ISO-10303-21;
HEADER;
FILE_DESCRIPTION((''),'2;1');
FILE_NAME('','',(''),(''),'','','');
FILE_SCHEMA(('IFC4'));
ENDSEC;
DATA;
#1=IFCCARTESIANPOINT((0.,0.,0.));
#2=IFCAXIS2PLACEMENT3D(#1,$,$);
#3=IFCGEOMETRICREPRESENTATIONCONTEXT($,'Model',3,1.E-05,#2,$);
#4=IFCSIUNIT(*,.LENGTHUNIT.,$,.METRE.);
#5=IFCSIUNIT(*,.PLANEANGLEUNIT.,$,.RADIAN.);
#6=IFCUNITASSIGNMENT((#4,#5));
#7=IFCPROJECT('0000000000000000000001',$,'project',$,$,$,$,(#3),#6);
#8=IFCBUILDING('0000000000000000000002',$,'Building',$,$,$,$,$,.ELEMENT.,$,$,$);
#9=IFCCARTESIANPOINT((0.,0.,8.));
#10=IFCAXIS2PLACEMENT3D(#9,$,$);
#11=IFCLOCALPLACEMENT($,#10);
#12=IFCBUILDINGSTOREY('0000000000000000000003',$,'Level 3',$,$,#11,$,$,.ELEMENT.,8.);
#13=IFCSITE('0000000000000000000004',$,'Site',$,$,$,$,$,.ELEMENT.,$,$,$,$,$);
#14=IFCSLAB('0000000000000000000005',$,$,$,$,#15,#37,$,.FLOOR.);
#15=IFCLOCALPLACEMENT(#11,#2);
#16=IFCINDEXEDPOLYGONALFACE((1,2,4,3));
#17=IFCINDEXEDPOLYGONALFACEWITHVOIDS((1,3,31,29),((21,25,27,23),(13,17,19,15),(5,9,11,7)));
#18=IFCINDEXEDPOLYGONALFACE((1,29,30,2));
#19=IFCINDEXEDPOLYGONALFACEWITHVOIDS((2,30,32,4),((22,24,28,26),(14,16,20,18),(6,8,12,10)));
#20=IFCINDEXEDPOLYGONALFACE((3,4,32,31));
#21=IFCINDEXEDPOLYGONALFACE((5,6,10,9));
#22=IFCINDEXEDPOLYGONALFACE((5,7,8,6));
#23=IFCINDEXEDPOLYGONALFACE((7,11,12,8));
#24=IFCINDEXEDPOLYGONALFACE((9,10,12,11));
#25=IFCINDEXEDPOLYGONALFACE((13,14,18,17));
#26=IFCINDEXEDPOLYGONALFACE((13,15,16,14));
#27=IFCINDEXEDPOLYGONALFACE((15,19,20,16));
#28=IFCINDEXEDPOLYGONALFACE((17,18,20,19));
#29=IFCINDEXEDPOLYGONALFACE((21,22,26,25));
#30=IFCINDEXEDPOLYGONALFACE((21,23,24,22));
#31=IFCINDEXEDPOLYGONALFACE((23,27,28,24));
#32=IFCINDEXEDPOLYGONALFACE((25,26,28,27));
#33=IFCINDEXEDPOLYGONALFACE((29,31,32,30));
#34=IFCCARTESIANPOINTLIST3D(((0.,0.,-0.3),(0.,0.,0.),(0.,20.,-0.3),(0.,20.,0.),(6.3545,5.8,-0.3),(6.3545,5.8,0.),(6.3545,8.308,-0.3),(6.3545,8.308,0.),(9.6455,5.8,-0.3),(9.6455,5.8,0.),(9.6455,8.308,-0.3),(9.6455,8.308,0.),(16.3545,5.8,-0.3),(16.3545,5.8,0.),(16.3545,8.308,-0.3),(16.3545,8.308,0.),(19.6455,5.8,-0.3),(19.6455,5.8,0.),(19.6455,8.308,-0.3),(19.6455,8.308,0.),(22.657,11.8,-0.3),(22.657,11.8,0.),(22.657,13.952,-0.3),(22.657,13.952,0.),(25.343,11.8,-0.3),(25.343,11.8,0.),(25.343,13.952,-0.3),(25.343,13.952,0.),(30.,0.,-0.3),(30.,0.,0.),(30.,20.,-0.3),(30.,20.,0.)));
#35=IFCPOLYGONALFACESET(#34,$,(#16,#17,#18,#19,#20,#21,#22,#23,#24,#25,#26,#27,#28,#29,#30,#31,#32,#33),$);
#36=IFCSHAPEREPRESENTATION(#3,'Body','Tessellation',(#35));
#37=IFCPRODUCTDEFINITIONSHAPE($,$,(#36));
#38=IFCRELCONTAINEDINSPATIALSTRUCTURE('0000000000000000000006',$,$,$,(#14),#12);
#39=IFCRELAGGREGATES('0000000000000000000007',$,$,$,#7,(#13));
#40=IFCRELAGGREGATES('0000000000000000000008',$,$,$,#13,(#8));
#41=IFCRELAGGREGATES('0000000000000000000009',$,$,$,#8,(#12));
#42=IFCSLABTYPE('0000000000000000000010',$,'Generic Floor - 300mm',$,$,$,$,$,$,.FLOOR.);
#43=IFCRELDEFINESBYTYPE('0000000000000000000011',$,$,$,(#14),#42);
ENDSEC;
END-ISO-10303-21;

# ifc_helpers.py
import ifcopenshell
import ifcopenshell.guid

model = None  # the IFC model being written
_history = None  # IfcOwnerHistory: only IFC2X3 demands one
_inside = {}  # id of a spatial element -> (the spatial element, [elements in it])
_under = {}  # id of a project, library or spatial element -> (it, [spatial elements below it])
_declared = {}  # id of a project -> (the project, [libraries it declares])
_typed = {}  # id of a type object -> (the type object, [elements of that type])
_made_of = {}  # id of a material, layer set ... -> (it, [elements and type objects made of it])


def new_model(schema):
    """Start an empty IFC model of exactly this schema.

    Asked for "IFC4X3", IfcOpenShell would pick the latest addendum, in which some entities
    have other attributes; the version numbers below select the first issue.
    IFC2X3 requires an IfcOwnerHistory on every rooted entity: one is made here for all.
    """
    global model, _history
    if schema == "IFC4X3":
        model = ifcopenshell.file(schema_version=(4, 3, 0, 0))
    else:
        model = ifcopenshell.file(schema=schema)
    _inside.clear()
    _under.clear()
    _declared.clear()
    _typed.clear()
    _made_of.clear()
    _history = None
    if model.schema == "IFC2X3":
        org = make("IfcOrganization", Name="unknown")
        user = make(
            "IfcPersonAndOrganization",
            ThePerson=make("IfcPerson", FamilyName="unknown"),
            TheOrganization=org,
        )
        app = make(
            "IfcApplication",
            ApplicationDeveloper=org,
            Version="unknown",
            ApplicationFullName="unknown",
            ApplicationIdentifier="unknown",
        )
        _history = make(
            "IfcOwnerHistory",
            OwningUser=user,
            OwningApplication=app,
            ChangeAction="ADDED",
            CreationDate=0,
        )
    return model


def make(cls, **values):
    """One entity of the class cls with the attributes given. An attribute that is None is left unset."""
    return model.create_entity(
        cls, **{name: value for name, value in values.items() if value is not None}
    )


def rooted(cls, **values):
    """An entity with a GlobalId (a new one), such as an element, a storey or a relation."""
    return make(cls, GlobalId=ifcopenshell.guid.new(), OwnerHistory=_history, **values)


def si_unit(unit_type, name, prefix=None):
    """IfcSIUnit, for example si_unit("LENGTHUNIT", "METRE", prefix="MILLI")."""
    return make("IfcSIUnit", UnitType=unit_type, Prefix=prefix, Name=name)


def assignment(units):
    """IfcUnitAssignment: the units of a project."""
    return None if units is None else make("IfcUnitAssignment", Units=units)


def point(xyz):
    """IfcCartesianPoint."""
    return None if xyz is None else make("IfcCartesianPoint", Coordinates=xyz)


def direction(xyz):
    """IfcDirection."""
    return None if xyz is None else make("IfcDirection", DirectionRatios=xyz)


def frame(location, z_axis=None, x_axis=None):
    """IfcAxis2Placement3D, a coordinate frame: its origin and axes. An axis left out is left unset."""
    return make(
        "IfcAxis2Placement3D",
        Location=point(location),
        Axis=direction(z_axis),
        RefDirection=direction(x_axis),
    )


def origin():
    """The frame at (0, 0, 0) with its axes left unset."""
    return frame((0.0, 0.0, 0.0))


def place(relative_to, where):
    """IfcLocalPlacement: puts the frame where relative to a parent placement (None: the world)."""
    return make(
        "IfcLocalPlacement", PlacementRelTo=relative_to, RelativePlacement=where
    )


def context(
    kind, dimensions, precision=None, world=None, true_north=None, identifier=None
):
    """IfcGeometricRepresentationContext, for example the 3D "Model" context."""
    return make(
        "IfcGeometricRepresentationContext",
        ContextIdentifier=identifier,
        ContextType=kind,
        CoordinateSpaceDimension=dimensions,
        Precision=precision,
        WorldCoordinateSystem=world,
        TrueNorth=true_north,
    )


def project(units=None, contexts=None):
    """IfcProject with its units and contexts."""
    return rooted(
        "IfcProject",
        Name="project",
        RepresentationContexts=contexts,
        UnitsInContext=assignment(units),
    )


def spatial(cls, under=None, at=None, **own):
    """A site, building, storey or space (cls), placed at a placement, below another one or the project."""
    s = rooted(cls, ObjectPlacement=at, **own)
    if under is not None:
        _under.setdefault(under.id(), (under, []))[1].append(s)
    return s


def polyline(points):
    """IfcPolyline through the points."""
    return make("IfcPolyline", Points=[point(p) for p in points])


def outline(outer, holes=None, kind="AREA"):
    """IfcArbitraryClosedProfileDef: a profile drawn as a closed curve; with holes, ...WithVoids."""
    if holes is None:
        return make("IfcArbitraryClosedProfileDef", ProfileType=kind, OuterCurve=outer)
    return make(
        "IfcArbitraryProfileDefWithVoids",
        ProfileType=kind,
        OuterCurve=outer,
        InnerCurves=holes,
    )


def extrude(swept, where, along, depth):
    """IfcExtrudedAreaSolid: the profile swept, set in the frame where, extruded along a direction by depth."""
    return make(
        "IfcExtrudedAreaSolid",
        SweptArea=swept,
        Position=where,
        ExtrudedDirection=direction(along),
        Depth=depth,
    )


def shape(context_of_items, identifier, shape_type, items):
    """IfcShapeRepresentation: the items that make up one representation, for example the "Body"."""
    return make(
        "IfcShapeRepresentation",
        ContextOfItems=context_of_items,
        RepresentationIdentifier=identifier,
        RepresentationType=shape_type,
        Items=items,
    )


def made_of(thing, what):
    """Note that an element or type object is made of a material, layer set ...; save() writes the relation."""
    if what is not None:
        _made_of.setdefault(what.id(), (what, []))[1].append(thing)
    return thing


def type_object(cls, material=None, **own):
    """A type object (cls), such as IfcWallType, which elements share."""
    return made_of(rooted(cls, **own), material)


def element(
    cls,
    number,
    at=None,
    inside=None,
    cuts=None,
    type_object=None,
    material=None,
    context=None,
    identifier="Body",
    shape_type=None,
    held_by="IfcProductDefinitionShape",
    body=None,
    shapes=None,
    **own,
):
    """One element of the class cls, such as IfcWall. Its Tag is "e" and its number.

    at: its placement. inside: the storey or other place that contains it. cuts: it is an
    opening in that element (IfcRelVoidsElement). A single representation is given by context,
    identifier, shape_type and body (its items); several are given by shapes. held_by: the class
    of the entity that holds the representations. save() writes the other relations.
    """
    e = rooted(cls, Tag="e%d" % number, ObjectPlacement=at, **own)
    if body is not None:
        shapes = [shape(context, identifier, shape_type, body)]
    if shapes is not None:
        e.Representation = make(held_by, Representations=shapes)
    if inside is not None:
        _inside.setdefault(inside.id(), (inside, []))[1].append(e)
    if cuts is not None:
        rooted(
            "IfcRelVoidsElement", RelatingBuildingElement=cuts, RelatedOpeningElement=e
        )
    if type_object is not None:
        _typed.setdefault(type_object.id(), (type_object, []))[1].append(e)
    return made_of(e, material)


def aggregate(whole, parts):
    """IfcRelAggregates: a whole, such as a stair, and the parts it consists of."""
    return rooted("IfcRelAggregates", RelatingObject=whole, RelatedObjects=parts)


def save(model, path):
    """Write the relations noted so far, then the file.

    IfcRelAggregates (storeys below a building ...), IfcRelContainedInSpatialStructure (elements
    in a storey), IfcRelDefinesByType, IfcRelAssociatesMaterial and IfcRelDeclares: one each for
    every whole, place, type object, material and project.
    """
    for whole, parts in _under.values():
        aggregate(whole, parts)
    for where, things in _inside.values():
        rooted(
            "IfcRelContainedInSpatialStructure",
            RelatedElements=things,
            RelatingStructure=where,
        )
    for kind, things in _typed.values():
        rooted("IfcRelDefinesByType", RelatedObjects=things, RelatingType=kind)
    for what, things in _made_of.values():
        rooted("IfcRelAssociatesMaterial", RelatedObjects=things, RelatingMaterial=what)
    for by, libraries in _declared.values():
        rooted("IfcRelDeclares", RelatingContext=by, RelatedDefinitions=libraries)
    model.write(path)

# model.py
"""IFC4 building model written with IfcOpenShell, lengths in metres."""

from ifc_helpers import new_model, si_unit, frame, origin, place, context, project, spatial, polyline, outline, extrude, type_object, element, save


model = new_model("IFC4")

# Units and contexts
model_context = context("Model", 3, precision=1e-05, world=origin())
ifc_project = project(units=[si_unit("LENGTHUNIT", "METRE"), si_unit("PLANEANGLEUNIT", "RADIAN")], contexts=[model_context])

# Site, building, storey
site = spatial("IfcSite", under=ifc_project, Name="Site", CompositionType="ELEMENT")
building = spatial("IfcBuilding", under=site, Name="Building", CompositionType="ELEMENT")
storey_placement = place(None, frame((0.0, 0.0, 8.0)))
storey = spatial("IfcBuildingStorey", under=building, at=storey_placement, Name="Level 3", CompositionType="ELEMENT", Elevation=8.0)

# Slab, openings
slab_type = type_object("IfcSlabType", Name="Generic Floor - 300mm", PredefinedType="FLOOR")
slab_placement = place(None, frame((0.0, 0.0, 8.0)))
slab = element("IfcSlab", 1, at=slab_placement, inside=storey, type_object=slab_type, PredefinedType="FLOOR", context=model_context, shape_type="SweptSolid", body=[
    extrude(outline(polyline([(0.0, 0.0), (30.0, 0.0), (30.0, 20.0), (0.0, 20.0), (0.0, 0.0)])), origin(), (0.0, 0.0, -1.0), 0.3),
])
opening_1_placement = place(None, frame((0.0, 0.0, 8.001)))
element("IfcOpeningElement", 2, at=opening_1_placement, cuts=slab, PredefinedType="OPENING", context=model_context, shape_type="SweptSolid", body=[
    extrude(outline(polyline([(6.3545, 5.8), (9.6455, 5.8), (9.6455, 8.308), (6.3545, 8.308), (6.3545, 5.8)])), origin(), (0.0, 0.0, -1.0), 0.302),
])
opening_2_placement = place(None, frame((0.0, 0.0, 8.001)))
element("IfcOpeningElement", 3, at=opening_2_placement, cuts=slab, PredefinedType="OPENING", context=model_context, shape_type="SweptSolid", body=[
    extrude(outline(polyline([(16.3545, 5.8), (19.6455, 5.8), (19.6455, 8.308), (16.3545, 8.308), (16.3545, 5.8)])), origin(), (0.0, 0.0, -1.0), 0.302),
])
opening_3_placement = place(None, frame((0.0, 0.0, 8.001)))
element("IfcOpeningElement", 4, at=opening_3_placement, cuts=slab, PredefinedType="OPENING", context=model_context, shape_type="SweptSolid", body=[
    extrude(outline(polyline([(22.657, 11.8), (25.343, 11.8), (25.343, 13.952), (22.657, 13.952), (22.657, 11.8)])), origin(), (0.0, 0.0, -1.0), 0.302),
])

save(model, "model.ifc")
